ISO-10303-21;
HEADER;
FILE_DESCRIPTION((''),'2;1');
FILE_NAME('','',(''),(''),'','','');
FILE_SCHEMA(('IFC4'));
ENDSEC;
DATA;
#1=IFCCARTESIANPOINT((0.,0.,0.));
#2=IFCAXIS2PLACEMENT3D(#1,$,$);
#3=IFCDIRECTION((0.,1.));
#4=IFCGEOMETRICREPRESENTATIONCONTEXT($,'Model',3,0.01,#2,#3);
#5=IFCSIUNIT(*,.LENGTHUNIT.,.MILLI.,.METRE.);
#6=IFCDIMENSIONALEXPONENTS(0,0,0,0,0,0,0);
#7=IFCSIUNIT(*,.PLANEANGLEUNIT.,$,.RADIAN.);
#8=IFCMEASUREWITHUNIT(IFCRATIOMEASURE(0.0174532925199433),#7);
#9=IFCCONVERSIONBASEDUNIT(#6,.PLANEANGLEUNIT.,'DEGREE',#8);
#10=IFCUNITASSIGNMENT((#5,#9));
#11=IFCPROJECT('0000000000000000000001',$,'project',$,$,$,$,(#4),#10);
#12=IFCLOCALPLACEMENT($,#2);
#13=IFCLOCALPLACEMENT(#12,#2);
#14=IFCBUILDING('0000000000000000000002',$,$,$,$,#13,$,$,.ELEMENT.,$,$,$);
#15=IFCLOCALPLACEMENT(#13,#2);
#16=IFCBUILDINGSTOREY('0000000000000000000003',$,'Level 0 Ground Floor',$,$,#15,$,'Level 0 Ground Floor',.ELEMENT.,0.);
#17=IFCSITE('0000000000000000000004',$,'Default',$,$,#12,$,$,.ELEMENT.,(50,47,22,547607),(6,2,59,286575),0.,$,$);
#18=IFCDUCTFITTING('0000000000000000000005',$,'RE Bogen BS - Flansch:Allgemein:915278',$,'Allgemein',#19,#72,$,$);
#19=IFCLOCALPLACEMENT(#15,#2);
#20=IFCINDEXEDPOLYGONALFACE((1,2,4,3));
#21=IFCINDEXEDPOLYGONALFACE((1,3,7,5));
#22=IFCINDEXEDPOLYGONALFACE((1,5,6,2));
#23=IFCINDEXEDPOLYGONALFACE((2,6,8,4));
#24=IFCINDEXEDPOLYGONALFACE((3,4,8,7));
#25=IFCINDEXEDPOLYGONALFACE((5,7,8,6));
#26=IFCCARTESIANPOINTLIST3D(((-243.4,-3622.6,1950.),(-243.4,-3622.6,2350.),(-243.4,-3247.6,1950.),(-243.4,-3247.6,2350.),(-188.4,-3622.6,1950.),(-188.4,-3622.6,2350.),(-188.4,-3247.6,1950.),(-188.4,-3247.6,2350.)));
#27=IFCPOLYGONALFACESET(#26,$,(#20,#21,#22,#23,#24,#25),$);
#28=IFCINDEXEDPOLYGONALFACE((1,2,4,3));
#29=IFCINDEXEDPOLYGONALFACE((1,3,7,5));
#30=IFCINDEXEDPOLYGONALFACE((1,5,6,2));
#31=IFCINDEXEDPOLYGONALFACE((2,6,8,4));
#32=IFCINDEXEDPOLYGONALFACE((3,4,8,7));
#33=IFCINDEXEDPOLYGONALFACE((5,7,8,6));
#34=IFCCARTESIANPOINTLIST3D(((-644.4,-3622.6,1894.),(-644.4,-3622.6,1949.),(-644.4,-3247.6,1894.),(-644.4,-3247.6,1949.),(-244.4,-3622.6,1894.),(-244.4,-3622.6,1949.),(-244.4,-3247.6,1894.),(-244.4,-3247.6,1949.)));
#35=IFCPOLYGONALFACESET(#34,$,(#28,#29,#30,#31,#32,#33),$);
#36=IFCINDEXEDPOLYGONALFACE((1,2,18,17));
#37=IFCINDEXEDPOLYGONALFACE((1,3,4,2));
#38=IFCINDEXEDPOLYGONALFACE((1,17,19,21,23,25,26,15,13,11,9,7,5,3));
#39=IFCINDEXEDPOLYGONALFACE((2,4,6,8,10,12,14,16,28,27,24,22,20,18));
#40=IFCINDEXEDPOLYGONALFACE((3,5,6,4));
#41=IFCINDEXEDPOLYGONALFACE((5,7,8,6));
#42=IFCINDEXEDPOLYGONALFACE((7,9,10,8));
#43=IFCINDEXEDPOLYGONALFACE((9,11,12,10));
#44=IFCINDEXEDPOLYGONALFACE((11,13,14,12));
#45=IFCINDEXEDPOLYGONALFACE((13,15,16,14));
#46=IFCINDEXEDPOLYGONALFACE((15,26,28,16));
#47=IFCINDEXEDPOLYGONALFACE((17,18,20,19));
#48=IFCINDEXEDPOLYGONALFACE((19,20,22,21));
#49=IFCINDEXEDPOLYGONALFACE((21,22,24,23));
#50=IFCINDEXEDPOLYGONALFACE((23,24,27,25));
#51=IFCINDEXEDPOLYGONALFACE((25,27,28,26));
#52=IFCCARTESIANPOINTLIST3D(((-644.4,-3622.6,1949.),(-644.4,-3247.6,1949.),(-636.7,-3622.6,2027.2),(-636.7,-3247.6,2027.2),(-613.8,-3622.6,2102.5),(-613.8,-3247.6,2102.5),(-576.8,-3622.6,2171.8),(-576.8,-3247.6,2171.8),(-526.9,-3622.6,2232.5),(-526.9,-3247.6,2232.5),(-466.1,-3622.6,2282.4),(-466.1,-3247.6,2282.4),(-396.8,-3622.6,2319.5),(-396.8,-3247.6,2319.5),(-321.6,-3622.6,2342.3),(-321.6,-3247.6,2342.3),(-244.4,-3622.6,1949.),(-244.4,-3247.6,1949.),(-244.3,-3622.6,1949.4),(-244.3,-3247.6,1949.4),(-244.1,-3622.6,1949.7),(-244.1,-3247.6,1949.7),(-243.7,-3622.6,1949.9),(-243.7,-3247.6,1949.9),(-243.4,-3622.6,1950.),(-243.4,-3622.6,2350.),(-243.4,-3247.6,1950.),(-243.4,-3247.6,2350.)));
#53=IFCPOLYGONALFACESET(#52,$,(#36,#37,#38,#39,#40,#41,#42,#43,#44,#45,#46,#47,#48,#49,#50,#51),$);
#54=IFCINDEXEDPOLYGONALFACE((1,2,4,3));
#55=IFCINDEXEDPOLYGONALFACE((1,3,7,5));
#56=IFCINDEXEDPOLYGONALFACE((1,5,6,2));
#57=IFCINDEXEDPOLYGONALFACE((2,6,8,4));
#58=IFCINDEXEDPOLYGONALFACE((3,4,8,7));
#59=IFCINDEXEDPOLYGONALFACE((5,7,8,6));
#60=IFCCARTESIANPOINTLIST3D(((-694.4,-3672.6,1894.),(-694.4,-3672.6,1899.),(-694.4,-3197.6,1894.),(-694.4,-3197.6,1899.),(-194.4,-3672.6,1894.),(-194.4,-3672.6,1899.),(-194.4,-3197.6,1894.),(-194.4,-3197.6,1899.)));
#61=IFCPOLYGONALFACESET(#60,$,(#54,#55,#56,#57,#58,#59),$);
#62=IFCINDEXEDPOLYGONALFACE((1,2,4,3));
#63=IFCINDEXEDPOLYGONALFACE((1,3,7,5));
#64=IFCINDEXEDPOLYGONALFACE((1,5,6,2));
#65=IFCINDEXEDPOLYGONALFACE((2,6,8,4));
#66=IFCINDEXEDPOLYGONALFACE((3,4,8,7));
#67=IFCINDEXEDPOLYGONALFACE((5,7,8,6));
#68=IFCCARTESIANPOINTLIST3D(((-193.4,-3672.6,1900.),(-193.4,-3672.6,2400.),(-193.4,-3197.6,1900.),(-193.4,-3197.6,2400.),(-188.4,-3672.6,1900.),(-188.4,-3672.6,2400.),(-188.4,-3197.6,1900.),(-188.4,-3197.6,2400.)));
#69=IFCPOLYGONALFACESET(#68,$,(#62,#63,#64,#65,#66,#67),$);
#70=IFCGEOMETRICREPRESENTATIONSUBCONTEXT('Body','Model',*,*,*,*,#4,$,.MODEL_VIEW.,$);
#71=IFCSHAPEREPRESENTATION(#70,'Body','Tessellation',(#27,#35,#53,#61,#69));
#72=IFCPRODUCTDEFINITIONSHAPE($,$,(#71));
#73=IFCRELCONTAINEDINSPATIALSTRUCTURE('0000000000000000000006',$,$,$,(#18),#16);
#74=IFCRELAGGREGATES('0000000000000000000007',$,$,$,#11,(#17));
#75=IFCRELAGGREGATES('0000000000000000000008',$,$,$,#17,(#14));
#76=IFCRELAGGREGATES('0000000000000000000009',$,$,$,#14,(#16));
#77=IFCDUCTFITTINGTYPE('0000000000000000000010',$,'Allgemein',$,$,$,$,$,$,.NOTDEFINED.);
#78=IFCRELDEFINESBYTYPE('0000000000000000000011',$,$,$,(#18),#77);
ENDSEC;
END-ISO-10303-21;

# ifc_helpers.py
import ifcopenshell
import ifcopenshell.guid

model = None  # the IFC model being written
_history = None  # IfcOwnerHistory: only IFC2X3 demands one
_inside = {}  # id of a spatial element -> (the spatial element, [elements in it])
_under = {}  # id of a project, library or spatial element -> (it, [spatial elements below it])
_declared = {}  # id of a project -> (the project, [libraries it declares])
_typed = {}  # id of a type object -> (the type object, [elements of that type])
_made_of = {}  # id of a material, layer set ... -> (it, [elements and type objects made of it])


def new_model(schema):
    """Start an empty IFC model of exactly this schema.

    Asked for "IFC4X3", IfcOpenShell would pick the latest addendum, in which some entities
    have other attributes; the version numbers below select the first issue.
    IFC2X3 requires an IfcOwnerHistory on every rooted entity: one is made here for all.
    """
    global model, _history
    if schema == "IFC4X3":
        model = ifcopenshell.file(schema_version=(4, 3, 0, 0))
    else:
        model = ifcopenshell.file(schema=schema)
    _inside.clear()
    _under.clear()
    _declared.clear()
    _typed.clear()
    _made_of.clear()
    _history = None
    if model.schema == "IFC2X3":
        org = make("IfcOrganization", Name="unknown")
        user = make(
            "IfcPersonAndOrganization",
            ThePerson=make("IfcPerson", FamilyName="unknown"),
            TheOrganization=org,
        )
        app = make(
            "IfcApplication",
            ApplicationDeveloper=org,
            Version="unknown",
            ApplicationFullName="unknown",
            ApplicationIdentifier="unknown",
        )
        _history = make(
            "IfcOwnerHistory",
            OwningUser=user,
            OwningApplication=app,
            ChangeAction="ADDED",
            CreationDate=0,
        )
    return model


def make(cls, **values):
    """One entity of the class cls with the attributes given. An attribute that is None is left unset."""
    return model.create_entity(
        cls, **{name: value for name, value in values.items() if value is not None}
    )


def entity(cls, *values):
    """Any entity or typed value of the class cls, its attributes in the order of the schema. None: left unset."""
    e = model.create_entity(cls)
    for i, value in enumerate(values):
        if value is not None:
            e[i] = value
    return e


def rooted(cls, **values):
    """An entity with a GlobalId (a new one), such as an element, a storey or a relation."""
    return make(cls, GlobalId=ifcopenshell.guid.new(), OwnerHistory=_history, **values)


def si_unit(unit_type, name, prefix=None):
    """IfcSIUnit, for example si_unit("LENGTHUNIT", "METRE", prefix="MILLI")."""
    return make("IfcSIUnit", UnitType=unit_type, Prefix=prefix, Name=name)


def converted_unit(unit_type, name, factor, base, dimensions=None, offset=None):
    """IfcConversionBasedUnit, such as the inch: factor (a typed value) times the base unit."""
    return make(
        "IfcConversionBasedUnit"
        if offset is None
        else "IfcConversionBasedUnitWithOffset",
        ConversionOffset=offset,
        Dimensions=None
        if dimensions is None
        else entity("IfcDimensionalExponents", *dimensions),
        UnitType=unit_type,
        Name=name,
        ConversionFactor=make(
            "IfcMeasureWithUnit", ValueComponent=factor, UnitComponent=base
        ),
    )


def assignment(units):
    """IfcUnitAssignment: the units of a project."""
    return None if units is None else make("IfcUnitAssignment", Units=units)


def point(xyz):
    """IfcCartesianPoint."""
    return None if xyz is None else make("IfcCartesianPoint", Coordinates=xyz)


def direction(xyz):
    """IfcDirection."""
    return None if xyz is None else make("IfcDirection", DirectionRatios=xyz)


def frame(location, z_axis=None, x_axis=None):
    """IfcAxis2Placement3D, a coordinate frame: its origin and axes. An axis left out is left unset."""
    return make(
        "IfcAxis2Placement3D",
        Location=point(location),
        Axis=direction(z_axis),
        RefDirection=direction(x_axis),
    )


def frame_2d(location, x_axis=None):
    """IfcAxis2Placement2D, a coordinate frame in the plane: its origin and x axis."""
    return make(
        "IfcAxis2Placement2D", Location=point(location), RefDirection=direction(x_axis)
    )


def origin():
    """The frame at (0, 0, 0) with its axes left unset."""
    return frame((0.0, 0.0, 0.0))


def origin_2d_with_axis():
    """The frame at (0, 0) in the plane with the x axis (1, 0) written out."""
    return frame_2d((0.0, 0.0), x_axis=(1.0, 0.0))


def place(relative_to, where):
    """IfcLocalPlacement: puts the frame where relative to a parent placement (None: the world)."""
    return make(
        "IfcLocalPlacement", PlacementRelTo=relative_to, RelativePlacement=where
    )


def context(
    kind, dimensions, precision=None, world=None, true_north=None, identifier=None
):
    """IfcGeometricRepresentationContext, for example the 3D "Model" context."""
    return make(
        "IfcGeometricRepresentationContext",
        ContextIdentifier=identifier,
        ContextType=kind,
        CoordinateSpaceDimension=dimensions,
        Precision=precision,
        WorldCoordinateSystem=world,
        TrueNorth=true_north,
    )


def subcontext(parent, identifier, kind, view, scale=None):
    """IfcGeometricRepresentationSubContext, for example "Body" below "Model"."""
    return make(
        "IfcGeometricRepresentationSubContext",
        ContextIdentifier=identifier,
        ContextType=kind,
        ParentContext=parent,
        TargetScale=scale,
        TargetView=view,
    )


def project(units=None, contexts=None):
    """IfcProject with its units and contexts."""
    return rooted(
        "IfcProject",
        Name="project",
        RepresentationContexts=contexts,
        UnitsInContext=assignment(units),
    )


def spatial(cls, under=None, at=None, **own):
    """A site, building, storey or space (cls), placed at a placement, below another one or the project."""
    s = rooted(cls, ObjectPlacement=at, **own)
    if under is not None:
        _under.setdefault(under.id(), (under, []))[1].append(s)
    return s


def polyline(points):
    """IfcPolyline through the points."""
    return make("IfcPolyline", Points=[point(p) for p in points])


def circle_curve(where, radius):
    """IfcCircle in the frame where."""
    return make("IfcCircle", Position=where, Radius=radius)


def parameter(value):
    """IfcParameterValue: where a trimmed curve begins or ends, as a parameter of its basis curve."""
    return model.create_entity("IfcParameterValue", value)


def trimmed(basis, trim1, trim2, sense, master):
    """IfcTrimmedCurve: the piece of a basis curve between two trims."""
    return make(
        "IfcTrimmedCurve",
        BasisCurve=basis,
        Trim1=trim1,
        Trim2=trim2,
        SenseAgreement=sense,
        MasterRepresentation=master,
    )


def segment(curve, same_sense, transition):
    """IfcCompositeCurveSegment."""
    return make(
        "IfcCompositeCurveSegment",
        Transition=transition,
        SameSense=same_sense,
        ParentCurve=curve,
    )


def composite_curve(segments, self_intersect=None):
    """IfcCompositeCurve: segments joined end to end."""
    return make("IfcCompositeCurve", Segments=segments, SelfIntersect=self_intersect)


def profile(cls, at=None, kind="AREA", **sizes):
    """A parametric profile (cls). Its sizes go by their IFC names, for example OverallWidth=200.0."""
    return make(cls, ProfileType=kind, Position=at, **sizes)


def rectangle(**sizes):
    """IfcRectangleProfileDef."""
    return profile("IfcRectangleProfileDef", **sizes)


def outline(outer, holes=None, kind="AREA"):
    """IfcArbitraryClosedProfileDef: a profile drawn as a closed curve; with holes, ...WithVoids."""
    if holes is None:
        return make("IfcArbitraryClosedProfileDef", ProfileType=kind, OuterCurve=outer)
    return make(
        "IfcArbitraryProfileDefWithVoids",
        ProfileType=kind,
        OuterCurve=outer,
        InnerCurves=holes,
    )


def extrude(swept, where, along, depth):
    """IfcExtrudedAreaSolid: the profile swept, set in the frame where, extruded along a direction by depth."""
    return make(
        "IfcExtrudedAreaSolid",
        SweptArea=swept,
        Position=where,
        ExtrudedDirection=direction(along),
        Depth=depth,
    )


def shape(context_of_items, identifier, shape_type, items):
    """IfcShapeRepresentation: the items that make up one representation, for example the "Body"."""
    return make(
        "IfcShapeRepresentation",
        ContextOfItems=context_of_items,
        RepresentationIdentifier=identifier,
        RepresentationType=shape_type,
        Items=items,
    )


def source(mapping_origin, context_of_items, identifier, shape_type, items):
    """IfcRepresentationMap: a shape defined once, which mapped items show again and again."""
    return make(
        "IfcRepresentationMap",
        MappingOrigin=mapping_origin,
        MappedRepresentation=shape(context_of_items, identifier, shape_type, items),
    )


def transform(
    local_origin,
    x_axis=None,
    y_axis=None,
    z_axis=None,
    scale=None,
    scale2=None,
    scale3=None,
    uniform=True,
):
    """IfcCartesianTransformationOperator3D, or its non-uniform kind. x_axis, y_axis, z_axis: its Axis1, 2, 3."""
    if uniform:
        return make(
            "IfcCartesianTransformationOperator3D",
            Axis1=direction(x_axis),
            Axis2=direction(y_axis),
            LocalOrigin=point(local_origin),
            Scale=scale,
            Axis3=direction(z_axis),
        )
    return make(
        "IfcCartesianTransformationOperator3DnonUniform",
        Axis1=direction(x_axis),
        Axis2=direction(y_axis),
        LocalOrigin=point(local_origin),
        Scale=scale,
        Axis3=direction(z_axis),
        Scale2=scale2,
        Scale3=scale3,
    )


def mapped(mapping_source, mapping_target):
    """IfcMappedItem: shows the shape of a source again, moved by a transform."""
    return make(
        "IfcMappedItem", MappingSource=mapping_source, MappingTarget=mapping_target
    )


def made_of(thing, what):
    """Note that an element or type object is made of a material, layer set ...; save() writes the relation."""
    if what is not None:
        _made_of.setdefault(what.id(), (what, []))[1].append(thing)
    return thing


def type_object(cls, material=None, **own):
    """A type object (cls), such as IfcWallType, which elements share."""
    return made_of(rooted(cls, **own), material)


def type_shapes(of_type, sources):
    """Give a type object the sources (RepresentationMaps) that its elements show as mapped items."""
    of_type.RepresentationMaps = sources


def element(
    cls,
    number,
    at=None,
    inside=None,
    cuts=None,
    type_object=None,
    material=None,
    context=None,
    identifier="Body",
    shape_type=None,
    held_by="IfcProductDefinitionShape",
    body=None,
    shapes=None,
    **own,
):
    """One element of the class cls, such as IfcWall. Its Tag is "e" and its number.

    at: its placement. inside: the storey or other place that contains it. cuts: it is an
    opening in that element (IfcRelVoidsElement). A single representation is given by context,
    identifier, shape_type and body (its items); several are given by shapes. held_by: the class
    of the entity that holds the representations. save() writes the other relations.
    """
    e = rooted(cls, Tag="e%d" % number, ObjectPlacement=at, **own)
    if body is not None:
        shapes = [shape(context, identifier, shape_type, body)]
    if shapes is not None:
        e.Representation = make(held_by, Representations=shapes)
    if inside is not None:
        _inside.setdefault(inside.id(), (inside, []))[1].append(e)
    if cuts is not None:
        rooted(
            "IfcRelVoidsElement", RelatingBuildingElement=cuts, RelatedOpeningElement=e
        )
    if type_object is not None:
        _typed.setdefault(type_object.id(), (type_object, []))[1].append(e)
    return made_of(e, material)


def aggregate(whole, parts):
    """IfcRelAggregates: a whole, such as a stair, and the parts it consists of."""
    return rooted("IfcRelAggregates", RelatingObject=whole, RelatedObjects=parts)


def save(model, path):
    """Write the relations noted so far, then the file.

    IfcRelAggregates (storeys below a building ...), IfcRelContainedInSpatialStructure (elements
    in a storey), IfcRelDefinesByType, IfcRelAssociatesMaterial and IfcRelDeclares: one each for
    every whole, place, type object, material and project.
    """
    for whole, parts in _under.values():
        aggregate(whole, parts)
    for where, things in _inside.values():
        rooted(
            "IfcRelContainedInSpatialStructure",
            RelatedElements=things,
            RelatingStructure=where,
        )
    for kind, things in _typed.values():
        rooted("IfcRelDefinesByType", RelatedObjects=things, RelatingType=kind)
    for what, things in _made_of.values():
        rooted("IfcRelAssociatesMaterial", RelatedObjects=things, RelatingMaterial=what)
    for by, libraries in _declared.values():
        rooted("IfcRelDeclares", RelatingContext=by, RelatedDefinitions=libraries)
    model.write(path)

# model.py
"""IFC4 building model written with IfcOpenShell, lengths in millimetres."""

from ifc_helpers import new_model, entity, si_unit, converted_unit, direction, frame, frame_2d, origin, origin_2d_with_axis, place, context, subcontext, project, spatial, polyline, circle_curve, parameter, trimmed, segment, composite_curve, rectangle, outline, extrude, source, transform, mapped, type_object, type_shapes, element, save


model = new_model("IFC4")

# Units and contexts
model_context = context("Model", 3, precision=0.01, world=origin(), true_north=direction((0.0, 1.0)))
body_context = subcontext(model_context, "Body", "Model", "MODEL_VIEW")
ifc_project = project(units=[si_unit("LENGTHUNIT", "METRE", prefix="MILLI"), converted_unit("PLANEANGLEUNIT", "DEGREE", entity("IfcRatioMeasure", 0.0174532925199433), si_unit("PLANEANGLEUNIT", "RADIAN"), dimensions=[0, 0, 0, 0, 0, 0, 0])], contexts=[model_context])

# Site, building, storey
site_placement = place(None, origin())
site = spatial("IfcSite", under=ifc_project, at=site_placement, Name="Default", CompositionType="ELEMENT", RefLatitude=(50, 47, 22, 547607), RefLongitude=(6, 2, 59, 286575), RefElevation=0.0)
building_placement = place(site_placement, origin())
building = spatial("IfcBuilding", under=site, at=building_placement, CompositionType="ELEMENT")
storey_placement = place(building_placement, origin())
storey = spatial("IfcBuildingStorey", under=building, at=storey_placement, Name="Level 0 Ground Floor", LongName="Level 0 Ground Floor", CompositionType="ELEMENT", Elevation=0.0)

# Duct fitting
duct_fitting_type = type_object("IfcDuctFittingType", Name="Allgemein", PredefinedType="NOTDEFINED")
shared_shape_1 = source(origin(), body_context, "Body", "SweptSolid", [
    extrude(rectangle(XDim=55.0, YDim=400.0, at=frame_2d((0.0, 0.0), x_axis=(1.0, 0.0))), frame((0.0, 228.5, -187.5), z_axis=(0.0, 0.0, 1.0), x_axis=(0.0, 1.0, 0.0)), (0.0, 0.0, 1.0), 375.0),
    extrude(rectangle(XDim=400.0, YDim=55.0, at=frame_2d((0.0, 0.0), x_axis=(1.0, 0.0))), frame((-228.5, 0.0, -187.5), z_axis=(0.0, 0.0, 1.0), x_axis=(0.0, -1.0, 0.0)), (0.0, 0.0, 1.0), 375.0),
    extrude(outline(composite_curve([segment(polyline([(-300.5, -100.5), (99.5, -100.5)]), True, "CONTINUOUS"), segment(trimmed(circle_curve(frame_2d((100.5, -100.5), x_axis=(0.0, 1.0)), 1.0), [parameter(0.0)], [parameter(90.0)], True, "PARAMETER"), False, "CONTINUOUS"), segment(polyline([(100.5, -99.5), (100.5, 300.5)]), True, "CONTINUOUS"), segment(trimmed(circle_curve(frame_2d((100.5, -100.5), x_axis=(0.0, 1.0)), 401.0), [parameter(0.0)], [parameter(90.0)], True, "PARAMETER"), True, "CONTINUOUS")], self_intersect=False)), frame((-100.5, 100.5, -187.5), z_axis=(0.0, 0.0, 1.0), x_axis=(-1.0, 0.0, 0.0)), (0.0, 0.0, 1.0), 375.0),
    extrude(rectangle(XDim=5.0, YDim=500.0, at=frame_2d((0.0, 0.0), x_axis=(1.0, 0.0))), frame((-253.5, 0.0, -237.5)), (0.0, 0.0, 1.0), 475.0),
    extrude(rectangle(XDim=5.0, YDim=500.0, at=origin_2d_with_axis()), frame((0.0, 253.5, -237.5), z_axis=(0.0, 0.0, 1.0), x_axis=(0.0, 1.0, 0.0)), (0.0, 0.0, 1.0), 475.0),
])
type_shapes(duct_fitting_type, [shared_shape_1])
duct_fitting_placement = place(storey_placement, frame((-444.4, -3435.1, 2150.0), z_axis=(0.0, 1.0, 0.0), x_axis=(0.0, 0.0, 1.0)))
element("IfcDuctFitting", 1, at=duct_fitting_placement, inside=storey, type_object=duct_fitting_type, Name="RE Bogen BS - Flansch:Allgemein:915278", ObjectType="Allgemein", context=body_context, shape_type="MappedRepresentation", body=[
    mapped(shared_shape_1, transform((0.0, 0.0, 0.0), scale=1.0)),
])

save(model, "model.ifc")
